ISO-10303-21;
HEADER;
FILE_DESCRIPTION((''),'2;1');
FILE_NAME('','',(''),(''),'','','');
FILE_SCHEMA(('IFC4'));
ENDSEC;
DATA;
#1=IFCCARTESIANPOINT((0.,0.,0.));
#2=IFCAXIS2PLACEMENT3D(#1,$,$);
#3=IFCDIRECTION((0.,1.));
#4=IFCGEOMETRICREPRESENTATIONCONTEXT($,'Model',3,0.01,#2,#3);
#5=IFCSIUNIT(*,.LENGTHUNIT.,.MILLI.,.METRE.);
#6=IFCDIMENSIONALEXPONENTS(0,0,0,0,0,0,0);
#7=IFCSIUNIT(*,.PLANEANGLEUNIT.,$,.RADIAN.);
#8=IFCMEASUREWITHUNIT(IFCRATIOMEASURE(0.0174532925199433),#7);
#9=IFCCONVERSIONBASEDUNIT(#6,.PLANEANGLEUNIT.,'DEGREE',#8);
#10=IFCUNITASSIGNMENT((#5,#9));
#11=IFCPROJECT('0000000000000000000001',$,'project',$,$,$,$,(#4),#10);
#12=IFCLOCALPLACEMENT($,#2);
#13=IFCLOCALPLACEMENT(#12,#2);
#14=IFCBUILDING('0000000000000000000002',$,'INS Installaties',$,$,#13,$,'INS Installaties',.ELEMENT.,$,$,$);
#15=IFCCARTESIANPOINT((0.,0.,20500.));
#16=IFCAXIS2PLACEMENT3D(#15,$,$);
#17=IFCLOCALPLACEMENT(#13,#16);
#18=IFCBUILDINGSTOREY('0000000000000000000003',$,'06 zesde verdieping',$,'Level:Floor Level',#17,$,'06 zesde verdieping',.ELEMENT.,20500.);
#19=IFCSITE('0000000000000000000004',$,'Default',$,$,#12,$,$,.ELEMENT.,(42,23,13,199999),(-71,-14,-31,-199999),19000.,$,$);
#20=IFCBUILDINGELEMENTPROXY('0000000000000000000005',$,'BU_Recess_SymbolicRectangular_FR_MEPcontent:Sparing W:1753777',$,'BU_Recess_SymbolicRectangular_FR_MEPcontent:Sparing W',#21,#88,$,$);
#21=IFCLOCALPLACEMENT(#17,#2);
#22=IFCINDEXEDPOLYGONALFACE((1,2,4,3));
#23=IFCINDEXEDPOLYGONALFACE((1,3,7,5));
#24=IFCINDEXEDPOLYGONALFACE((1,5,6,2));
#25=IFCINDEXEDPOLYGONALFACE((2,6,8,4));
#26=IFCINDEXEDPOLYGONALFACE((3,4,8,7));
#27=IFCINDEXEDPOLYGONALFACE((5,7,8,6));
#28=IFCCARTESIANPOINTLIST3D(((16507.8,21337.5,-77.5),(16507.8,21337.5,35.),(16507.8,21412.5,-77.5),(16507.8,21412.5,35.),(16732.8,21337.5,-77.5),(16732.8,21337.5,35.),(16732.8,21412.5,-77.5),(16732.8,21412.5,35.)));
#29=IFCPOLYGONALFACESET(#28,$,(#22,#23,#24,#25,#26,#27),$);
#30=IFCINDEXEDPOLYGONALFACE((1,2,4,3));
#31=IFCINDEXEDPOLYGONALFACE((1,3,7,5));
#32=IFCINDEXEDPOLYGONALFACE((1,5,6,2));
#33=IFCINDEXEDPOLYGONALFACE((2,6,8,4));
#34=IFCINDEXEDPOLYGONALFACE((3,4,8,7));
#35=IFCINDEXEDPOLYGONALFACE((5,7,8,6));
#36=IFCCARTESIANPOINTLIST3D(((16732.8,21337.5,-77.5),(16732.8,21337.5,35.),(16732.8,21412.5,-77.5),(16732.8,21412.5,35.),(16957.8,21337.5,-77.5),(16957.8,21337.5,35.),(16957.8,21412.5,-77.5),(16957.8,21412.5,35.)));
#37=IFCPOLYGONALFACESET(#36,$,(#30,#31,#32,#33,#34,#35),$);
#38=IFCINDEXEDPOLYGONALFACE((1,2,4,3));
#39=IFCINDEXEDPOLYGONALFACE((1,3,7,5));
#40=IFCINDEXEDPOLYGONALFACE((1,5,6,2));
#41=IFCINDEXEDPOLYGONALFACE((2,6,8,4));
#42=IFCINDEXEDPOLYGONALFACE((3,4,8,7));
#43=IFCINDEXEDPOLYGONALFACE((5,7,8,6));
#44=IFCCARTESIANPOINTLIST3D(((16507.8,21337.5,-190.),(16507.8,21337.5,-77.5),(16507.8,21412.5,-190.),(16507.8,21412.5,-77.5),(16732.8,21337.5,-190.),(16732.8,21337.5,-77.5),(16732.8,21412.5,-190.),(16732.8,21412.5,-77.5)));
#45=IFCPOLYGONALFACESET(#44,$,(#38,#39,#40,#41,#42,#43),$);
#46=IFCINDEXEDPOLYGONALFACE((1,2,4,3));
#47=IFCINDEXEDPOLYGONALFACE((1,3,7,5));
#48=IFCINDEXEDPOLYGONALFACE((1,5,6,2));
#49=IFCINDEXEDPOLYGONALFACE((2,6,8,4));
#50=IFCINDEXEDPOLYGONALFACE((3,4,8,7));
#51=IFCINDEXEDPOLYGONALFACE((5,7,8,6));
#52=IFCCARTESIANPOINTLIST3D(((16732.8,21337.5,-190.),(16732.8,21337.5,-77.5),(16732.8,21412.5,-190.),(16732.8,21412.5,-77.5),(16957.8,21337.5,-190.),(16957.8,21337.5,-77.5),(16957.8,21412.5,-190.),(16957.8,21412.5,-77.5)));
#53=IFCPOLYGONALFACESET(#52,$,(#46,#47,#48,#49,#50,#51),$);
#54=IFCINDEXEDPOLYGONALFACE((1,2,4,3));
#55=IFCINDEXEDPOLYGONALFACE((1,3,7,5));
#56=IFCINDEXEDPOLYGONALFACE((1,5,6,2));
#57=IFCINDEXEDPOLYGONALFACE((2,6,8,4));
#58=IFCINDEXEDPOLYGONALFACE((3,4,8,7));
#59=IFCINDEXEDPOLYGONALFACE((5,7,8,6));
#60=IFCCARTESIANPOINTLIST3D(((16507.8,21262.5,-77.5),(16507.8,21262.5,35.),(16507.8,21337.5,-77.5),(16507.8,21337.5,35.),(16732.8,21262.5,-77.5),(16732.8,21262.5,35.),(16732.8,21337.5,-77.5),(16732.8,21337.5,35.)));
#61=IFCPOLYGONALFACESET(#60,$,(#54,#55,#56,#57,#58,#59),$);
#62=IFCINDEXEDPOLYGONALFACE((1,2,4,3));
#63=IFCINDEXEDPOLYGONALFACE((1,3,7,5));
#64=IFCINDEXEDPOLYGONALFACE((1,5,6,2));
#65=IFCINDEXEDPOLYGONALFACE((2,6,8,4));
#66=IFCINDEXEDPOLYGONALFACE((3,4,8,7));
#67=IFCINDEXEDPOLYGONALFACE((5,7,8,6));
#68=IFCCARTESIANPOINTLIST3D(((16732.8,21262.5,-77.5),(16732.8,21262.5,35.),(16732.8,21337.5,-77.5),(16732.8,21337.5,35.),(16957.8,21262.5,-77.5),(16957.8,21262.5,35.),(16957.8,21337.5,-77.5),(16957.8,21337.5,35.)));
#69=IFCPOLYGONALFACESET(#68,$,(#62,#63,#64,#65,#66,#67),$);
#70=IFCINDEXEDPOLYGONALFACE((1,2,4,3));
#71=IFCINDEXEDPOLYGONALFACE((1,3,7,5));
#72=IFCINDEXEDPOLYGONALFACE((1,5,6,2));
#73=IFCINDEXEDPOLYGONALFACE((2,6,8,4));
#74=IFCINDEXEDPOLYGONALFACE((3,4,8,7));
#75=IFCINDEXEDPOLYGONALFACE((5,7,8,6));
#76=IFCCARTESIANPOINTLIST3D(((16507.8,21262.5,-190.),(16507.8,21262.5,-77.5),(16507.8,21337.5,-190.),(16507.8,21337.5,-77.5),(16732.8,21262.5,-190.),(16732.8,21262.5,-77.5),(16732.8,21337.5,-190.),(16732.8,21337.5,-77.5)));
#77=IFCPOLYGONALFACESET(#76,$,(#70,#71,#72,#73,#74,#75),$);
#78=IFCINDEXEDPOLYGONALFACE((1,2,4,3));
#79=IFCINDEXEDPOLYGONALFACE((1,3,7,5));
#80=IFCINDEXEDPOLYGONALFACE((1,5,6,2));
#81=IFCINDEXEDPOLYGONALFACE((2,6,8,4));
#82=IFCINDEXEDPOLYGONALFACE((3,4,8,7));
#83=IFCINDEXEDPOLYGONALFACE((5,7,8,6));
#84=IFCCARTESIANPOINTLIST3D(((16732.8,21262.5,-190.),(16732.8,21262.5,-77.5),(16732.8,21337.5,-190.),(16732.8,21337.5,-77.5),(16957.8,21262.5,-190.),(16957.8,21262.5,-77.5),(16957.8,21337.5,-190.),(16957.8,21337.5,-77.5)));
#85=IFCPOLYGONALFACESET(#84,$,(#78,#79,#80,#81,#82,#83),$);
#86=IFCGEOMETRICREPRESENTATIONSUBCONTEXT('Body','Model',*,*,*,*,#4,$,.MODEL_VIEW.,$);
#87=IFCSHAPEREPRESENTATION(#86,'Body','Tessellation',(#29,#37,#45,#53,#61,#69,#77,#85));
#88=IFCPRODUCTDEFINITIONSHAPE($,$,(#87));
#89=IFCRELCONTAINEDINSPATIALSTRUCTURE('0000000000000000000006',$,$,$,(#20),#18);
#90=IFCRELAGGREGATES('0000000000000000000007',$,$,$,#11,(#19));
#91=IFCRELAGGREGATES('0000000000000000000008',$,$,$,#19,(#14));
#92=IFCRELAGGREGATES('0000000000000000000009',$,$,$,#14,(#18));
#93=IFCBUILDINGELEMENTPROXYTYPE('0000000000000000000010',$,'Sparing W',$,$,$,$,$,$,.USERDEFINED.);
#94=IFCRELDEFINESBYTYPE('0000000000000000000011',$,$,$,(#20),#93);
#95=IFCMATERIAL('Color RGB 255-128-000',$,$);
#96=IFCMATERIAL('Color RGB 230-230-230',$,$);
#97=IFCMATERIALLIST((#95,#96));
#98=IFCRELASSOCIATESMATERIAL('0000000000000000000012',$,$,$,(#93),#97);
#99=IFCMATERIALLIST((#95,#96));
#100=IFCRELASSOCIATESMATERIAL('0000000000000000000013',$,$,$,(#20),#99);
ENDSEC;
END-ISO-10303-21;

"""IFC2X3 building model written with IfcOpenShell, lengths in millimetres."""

from ifc_helpers import new_model, entity, si_unit, converted_unit, direction, frame, frame_2d, origin, origin_2d_with_axis, place, context, subcontext, project, spatial, rectangle, extrude, source, transform, mapped, material, material_list, type_object, type_shapes, element, save


model = new_model("IFC2X3")

# Units and contexts
model_context = context("Model", 3, precision=0.01, world=origin(), true_north=direction((0.0, 1.0)))
body_context = subcontext(model_context, "Body", "Model", "MODEL_VIEW")
ifc_project = project(units=[si_unit("LENGTHUNIT", "METRE", prefix="MILLI"), converted_unit("PLANEANGLEUNIT", "DEGREE", entity("IfcRatioMeasure", 0.0174532925199433), si_unit("PLANEANGLEUNIT", "RADIAN"), dimensions=[0, 0, 0, 0, 0, 0, 0])], contexts=[model_context])

# Site, building, storey
site_placement = place(None, origin())
site = spatial("IfcSite", under=ifc_project, at=site_placement, Name="Default", CompositionType="ELEMENT", RefLatitude=(42, 23, 13, 199999), RefLongitude=(-71, -14, -31, -199999), RefElevation=19000.0)
building_placement = place(site_placement, origin())
building = spatial("IfcBuilding", under=site, at=building_placement, Name="INS Installaties", LongName="INS Installaties", CompositionType="ELEMENT")
storey_placement = place(building_placement, frame((0.0, 0.0, 20500.0)))
storey = spatial("IfcBuildingStorey", under=building, at=storey_placement, Name="06 zesde verdieping", ObjectType="Level:Floor Level", LongName="06 zesde verdieping", CompositionType="ELEMENT", Elevation=20500.0)

# Building element proxy
ifc_material_1 = material(Name="Color RGB 255-128-000")
ifc_material_2 = material(Name="Color RGB 230-230-230")
ifc_material_list_1 = material_list([ifc_material_1, ifc_material_2])
ifc_material_list_2 = material_list([ifc_material_1, ifc_material_2])
building_element_proxy_type_1 = type_object("IfcBuildingElementProxyType", Name="Sparing W", PredefinedType="USERDEFINED", material=ifc_material_list_2)
shared_shape_1 = source(origin(), body_context, "Body", "SweptSolid", [
    extrude(rectangle(XDim=75.0, YDim=225.0, at=frame_2d((0.0, 0.0), x_axis=(1.0, 0.0))), frame((112.5, -109.5, 0.0), z_axis=(0.0, 0.0, 1.0), x_axis=(0.0, -1.0, 0.0)), (0.0, 0.0, 1.0), 112.5),
    extrude(rectangle(XDim=75.0, YDim=225.0, at=frame_2d((0.0, 0.0), x_axis=(1.0, 0.0))), frame((-112.5, -109.5, 0.0), z_axis=(0.0, 0.0, 1.0), x_axis=(0.0, -1.0, 0.0)), (0.0, 0.0, 1.0), 112.5),
    extrude(rectangle(XDim=75.0, YDim=225.0, at=origin_2d_with_axis()), frame((112.5, -109.5, -112.5), z_axis=(0.0, 0.0, 1.0), x_axis=(0.0, -1.0, 0.0)), (0.0, 0.0, 1.0), 112.5),
    extrude(rectangle(XDim=75.0, YDim=225.0, at=frame_2d((0.0, 0.0), x_axis=(1.0, 0.0))), frame((-112.5, -109.5, -112.5), z_axis=(0.0, 0.0, 1.0), x_axis=(0.0, -1.0, 0.0)), (0.0, 0.0, 1.0), 112.5),
    extrude(rectangle(XDim=75.0, YDim=225.0, at=origin_2d_with_axis()), frame((112.5, -34.5, 0.0), z_axis=(0.0, 0.0, 1.0), x_axis=(0.0, -1.0, 0.0)), (0.0, 0.0, 1.0), 112.5),
    extrude(rectangle(XDim=75.0, YDim=225.0, at=frame_2d((0.0, 0.0), x_axis=(1.0, 0.0))), frame((-112.5, -34.5, 0.0), z_axis=(0.0, 0.0, 1.0), x_axis=(0.0, -1.0, 0.0)), (0.0, 0.0, 1.0), 112.5),
    extrude(rectangle(XDim=75.0, YDim=225.0, at=frame_2d((0.0, 0.0), x_axis=(1.0, 0.0))), frame((112.5, -34.5, -112.5), z_axis=(0.0, 0.0, 1.0), x_axis=(0.0, -1.0, 0.0)), (0.0, 0.0, 1.0), 112.5),
    extrude(rectangle(XDim=75.0, YDim=225.0, at=frame_2d((0.0, 0.0), x_axis=(1.0, 0.0))), frame((-112.5, -34.5, -112.5), z_axis=(0.0, 0.0, 1.0), x_axis=(0.0, -1.0, 0.0)), (0.0, 0.0, 1.0), 112.5),
])
type_shapes(building_element_proxy_type_1, [shared_shape_1])
proxy_1_placement = place(storey_placement, frame((16732.8, 21265.5, -77.5), z_axis=(0.0, 0.0, 1.0), x_axis=(-1.0, 0.0, 0.0)))
element("IfcBuildingElementProxy", 1, at=proxy_1_placement, inside=storey, type_object=building_element_proxy_type_1, material=ifc_material_list_1, Name="BU_Recess_SymbolicRectangular_FR_MEPcontent:Sparing W:1753777", ObjectType="BU_Recess_SymbolicRectangular_FR_MEPcontent:Sparing W", context=body_context, shape_type="MappedRepresentation", body=[
    mapped(shared_shape_1, transform((0.0, 0.0, 0.0), scale=1.0)),
])

save(model, "model.ifc")
